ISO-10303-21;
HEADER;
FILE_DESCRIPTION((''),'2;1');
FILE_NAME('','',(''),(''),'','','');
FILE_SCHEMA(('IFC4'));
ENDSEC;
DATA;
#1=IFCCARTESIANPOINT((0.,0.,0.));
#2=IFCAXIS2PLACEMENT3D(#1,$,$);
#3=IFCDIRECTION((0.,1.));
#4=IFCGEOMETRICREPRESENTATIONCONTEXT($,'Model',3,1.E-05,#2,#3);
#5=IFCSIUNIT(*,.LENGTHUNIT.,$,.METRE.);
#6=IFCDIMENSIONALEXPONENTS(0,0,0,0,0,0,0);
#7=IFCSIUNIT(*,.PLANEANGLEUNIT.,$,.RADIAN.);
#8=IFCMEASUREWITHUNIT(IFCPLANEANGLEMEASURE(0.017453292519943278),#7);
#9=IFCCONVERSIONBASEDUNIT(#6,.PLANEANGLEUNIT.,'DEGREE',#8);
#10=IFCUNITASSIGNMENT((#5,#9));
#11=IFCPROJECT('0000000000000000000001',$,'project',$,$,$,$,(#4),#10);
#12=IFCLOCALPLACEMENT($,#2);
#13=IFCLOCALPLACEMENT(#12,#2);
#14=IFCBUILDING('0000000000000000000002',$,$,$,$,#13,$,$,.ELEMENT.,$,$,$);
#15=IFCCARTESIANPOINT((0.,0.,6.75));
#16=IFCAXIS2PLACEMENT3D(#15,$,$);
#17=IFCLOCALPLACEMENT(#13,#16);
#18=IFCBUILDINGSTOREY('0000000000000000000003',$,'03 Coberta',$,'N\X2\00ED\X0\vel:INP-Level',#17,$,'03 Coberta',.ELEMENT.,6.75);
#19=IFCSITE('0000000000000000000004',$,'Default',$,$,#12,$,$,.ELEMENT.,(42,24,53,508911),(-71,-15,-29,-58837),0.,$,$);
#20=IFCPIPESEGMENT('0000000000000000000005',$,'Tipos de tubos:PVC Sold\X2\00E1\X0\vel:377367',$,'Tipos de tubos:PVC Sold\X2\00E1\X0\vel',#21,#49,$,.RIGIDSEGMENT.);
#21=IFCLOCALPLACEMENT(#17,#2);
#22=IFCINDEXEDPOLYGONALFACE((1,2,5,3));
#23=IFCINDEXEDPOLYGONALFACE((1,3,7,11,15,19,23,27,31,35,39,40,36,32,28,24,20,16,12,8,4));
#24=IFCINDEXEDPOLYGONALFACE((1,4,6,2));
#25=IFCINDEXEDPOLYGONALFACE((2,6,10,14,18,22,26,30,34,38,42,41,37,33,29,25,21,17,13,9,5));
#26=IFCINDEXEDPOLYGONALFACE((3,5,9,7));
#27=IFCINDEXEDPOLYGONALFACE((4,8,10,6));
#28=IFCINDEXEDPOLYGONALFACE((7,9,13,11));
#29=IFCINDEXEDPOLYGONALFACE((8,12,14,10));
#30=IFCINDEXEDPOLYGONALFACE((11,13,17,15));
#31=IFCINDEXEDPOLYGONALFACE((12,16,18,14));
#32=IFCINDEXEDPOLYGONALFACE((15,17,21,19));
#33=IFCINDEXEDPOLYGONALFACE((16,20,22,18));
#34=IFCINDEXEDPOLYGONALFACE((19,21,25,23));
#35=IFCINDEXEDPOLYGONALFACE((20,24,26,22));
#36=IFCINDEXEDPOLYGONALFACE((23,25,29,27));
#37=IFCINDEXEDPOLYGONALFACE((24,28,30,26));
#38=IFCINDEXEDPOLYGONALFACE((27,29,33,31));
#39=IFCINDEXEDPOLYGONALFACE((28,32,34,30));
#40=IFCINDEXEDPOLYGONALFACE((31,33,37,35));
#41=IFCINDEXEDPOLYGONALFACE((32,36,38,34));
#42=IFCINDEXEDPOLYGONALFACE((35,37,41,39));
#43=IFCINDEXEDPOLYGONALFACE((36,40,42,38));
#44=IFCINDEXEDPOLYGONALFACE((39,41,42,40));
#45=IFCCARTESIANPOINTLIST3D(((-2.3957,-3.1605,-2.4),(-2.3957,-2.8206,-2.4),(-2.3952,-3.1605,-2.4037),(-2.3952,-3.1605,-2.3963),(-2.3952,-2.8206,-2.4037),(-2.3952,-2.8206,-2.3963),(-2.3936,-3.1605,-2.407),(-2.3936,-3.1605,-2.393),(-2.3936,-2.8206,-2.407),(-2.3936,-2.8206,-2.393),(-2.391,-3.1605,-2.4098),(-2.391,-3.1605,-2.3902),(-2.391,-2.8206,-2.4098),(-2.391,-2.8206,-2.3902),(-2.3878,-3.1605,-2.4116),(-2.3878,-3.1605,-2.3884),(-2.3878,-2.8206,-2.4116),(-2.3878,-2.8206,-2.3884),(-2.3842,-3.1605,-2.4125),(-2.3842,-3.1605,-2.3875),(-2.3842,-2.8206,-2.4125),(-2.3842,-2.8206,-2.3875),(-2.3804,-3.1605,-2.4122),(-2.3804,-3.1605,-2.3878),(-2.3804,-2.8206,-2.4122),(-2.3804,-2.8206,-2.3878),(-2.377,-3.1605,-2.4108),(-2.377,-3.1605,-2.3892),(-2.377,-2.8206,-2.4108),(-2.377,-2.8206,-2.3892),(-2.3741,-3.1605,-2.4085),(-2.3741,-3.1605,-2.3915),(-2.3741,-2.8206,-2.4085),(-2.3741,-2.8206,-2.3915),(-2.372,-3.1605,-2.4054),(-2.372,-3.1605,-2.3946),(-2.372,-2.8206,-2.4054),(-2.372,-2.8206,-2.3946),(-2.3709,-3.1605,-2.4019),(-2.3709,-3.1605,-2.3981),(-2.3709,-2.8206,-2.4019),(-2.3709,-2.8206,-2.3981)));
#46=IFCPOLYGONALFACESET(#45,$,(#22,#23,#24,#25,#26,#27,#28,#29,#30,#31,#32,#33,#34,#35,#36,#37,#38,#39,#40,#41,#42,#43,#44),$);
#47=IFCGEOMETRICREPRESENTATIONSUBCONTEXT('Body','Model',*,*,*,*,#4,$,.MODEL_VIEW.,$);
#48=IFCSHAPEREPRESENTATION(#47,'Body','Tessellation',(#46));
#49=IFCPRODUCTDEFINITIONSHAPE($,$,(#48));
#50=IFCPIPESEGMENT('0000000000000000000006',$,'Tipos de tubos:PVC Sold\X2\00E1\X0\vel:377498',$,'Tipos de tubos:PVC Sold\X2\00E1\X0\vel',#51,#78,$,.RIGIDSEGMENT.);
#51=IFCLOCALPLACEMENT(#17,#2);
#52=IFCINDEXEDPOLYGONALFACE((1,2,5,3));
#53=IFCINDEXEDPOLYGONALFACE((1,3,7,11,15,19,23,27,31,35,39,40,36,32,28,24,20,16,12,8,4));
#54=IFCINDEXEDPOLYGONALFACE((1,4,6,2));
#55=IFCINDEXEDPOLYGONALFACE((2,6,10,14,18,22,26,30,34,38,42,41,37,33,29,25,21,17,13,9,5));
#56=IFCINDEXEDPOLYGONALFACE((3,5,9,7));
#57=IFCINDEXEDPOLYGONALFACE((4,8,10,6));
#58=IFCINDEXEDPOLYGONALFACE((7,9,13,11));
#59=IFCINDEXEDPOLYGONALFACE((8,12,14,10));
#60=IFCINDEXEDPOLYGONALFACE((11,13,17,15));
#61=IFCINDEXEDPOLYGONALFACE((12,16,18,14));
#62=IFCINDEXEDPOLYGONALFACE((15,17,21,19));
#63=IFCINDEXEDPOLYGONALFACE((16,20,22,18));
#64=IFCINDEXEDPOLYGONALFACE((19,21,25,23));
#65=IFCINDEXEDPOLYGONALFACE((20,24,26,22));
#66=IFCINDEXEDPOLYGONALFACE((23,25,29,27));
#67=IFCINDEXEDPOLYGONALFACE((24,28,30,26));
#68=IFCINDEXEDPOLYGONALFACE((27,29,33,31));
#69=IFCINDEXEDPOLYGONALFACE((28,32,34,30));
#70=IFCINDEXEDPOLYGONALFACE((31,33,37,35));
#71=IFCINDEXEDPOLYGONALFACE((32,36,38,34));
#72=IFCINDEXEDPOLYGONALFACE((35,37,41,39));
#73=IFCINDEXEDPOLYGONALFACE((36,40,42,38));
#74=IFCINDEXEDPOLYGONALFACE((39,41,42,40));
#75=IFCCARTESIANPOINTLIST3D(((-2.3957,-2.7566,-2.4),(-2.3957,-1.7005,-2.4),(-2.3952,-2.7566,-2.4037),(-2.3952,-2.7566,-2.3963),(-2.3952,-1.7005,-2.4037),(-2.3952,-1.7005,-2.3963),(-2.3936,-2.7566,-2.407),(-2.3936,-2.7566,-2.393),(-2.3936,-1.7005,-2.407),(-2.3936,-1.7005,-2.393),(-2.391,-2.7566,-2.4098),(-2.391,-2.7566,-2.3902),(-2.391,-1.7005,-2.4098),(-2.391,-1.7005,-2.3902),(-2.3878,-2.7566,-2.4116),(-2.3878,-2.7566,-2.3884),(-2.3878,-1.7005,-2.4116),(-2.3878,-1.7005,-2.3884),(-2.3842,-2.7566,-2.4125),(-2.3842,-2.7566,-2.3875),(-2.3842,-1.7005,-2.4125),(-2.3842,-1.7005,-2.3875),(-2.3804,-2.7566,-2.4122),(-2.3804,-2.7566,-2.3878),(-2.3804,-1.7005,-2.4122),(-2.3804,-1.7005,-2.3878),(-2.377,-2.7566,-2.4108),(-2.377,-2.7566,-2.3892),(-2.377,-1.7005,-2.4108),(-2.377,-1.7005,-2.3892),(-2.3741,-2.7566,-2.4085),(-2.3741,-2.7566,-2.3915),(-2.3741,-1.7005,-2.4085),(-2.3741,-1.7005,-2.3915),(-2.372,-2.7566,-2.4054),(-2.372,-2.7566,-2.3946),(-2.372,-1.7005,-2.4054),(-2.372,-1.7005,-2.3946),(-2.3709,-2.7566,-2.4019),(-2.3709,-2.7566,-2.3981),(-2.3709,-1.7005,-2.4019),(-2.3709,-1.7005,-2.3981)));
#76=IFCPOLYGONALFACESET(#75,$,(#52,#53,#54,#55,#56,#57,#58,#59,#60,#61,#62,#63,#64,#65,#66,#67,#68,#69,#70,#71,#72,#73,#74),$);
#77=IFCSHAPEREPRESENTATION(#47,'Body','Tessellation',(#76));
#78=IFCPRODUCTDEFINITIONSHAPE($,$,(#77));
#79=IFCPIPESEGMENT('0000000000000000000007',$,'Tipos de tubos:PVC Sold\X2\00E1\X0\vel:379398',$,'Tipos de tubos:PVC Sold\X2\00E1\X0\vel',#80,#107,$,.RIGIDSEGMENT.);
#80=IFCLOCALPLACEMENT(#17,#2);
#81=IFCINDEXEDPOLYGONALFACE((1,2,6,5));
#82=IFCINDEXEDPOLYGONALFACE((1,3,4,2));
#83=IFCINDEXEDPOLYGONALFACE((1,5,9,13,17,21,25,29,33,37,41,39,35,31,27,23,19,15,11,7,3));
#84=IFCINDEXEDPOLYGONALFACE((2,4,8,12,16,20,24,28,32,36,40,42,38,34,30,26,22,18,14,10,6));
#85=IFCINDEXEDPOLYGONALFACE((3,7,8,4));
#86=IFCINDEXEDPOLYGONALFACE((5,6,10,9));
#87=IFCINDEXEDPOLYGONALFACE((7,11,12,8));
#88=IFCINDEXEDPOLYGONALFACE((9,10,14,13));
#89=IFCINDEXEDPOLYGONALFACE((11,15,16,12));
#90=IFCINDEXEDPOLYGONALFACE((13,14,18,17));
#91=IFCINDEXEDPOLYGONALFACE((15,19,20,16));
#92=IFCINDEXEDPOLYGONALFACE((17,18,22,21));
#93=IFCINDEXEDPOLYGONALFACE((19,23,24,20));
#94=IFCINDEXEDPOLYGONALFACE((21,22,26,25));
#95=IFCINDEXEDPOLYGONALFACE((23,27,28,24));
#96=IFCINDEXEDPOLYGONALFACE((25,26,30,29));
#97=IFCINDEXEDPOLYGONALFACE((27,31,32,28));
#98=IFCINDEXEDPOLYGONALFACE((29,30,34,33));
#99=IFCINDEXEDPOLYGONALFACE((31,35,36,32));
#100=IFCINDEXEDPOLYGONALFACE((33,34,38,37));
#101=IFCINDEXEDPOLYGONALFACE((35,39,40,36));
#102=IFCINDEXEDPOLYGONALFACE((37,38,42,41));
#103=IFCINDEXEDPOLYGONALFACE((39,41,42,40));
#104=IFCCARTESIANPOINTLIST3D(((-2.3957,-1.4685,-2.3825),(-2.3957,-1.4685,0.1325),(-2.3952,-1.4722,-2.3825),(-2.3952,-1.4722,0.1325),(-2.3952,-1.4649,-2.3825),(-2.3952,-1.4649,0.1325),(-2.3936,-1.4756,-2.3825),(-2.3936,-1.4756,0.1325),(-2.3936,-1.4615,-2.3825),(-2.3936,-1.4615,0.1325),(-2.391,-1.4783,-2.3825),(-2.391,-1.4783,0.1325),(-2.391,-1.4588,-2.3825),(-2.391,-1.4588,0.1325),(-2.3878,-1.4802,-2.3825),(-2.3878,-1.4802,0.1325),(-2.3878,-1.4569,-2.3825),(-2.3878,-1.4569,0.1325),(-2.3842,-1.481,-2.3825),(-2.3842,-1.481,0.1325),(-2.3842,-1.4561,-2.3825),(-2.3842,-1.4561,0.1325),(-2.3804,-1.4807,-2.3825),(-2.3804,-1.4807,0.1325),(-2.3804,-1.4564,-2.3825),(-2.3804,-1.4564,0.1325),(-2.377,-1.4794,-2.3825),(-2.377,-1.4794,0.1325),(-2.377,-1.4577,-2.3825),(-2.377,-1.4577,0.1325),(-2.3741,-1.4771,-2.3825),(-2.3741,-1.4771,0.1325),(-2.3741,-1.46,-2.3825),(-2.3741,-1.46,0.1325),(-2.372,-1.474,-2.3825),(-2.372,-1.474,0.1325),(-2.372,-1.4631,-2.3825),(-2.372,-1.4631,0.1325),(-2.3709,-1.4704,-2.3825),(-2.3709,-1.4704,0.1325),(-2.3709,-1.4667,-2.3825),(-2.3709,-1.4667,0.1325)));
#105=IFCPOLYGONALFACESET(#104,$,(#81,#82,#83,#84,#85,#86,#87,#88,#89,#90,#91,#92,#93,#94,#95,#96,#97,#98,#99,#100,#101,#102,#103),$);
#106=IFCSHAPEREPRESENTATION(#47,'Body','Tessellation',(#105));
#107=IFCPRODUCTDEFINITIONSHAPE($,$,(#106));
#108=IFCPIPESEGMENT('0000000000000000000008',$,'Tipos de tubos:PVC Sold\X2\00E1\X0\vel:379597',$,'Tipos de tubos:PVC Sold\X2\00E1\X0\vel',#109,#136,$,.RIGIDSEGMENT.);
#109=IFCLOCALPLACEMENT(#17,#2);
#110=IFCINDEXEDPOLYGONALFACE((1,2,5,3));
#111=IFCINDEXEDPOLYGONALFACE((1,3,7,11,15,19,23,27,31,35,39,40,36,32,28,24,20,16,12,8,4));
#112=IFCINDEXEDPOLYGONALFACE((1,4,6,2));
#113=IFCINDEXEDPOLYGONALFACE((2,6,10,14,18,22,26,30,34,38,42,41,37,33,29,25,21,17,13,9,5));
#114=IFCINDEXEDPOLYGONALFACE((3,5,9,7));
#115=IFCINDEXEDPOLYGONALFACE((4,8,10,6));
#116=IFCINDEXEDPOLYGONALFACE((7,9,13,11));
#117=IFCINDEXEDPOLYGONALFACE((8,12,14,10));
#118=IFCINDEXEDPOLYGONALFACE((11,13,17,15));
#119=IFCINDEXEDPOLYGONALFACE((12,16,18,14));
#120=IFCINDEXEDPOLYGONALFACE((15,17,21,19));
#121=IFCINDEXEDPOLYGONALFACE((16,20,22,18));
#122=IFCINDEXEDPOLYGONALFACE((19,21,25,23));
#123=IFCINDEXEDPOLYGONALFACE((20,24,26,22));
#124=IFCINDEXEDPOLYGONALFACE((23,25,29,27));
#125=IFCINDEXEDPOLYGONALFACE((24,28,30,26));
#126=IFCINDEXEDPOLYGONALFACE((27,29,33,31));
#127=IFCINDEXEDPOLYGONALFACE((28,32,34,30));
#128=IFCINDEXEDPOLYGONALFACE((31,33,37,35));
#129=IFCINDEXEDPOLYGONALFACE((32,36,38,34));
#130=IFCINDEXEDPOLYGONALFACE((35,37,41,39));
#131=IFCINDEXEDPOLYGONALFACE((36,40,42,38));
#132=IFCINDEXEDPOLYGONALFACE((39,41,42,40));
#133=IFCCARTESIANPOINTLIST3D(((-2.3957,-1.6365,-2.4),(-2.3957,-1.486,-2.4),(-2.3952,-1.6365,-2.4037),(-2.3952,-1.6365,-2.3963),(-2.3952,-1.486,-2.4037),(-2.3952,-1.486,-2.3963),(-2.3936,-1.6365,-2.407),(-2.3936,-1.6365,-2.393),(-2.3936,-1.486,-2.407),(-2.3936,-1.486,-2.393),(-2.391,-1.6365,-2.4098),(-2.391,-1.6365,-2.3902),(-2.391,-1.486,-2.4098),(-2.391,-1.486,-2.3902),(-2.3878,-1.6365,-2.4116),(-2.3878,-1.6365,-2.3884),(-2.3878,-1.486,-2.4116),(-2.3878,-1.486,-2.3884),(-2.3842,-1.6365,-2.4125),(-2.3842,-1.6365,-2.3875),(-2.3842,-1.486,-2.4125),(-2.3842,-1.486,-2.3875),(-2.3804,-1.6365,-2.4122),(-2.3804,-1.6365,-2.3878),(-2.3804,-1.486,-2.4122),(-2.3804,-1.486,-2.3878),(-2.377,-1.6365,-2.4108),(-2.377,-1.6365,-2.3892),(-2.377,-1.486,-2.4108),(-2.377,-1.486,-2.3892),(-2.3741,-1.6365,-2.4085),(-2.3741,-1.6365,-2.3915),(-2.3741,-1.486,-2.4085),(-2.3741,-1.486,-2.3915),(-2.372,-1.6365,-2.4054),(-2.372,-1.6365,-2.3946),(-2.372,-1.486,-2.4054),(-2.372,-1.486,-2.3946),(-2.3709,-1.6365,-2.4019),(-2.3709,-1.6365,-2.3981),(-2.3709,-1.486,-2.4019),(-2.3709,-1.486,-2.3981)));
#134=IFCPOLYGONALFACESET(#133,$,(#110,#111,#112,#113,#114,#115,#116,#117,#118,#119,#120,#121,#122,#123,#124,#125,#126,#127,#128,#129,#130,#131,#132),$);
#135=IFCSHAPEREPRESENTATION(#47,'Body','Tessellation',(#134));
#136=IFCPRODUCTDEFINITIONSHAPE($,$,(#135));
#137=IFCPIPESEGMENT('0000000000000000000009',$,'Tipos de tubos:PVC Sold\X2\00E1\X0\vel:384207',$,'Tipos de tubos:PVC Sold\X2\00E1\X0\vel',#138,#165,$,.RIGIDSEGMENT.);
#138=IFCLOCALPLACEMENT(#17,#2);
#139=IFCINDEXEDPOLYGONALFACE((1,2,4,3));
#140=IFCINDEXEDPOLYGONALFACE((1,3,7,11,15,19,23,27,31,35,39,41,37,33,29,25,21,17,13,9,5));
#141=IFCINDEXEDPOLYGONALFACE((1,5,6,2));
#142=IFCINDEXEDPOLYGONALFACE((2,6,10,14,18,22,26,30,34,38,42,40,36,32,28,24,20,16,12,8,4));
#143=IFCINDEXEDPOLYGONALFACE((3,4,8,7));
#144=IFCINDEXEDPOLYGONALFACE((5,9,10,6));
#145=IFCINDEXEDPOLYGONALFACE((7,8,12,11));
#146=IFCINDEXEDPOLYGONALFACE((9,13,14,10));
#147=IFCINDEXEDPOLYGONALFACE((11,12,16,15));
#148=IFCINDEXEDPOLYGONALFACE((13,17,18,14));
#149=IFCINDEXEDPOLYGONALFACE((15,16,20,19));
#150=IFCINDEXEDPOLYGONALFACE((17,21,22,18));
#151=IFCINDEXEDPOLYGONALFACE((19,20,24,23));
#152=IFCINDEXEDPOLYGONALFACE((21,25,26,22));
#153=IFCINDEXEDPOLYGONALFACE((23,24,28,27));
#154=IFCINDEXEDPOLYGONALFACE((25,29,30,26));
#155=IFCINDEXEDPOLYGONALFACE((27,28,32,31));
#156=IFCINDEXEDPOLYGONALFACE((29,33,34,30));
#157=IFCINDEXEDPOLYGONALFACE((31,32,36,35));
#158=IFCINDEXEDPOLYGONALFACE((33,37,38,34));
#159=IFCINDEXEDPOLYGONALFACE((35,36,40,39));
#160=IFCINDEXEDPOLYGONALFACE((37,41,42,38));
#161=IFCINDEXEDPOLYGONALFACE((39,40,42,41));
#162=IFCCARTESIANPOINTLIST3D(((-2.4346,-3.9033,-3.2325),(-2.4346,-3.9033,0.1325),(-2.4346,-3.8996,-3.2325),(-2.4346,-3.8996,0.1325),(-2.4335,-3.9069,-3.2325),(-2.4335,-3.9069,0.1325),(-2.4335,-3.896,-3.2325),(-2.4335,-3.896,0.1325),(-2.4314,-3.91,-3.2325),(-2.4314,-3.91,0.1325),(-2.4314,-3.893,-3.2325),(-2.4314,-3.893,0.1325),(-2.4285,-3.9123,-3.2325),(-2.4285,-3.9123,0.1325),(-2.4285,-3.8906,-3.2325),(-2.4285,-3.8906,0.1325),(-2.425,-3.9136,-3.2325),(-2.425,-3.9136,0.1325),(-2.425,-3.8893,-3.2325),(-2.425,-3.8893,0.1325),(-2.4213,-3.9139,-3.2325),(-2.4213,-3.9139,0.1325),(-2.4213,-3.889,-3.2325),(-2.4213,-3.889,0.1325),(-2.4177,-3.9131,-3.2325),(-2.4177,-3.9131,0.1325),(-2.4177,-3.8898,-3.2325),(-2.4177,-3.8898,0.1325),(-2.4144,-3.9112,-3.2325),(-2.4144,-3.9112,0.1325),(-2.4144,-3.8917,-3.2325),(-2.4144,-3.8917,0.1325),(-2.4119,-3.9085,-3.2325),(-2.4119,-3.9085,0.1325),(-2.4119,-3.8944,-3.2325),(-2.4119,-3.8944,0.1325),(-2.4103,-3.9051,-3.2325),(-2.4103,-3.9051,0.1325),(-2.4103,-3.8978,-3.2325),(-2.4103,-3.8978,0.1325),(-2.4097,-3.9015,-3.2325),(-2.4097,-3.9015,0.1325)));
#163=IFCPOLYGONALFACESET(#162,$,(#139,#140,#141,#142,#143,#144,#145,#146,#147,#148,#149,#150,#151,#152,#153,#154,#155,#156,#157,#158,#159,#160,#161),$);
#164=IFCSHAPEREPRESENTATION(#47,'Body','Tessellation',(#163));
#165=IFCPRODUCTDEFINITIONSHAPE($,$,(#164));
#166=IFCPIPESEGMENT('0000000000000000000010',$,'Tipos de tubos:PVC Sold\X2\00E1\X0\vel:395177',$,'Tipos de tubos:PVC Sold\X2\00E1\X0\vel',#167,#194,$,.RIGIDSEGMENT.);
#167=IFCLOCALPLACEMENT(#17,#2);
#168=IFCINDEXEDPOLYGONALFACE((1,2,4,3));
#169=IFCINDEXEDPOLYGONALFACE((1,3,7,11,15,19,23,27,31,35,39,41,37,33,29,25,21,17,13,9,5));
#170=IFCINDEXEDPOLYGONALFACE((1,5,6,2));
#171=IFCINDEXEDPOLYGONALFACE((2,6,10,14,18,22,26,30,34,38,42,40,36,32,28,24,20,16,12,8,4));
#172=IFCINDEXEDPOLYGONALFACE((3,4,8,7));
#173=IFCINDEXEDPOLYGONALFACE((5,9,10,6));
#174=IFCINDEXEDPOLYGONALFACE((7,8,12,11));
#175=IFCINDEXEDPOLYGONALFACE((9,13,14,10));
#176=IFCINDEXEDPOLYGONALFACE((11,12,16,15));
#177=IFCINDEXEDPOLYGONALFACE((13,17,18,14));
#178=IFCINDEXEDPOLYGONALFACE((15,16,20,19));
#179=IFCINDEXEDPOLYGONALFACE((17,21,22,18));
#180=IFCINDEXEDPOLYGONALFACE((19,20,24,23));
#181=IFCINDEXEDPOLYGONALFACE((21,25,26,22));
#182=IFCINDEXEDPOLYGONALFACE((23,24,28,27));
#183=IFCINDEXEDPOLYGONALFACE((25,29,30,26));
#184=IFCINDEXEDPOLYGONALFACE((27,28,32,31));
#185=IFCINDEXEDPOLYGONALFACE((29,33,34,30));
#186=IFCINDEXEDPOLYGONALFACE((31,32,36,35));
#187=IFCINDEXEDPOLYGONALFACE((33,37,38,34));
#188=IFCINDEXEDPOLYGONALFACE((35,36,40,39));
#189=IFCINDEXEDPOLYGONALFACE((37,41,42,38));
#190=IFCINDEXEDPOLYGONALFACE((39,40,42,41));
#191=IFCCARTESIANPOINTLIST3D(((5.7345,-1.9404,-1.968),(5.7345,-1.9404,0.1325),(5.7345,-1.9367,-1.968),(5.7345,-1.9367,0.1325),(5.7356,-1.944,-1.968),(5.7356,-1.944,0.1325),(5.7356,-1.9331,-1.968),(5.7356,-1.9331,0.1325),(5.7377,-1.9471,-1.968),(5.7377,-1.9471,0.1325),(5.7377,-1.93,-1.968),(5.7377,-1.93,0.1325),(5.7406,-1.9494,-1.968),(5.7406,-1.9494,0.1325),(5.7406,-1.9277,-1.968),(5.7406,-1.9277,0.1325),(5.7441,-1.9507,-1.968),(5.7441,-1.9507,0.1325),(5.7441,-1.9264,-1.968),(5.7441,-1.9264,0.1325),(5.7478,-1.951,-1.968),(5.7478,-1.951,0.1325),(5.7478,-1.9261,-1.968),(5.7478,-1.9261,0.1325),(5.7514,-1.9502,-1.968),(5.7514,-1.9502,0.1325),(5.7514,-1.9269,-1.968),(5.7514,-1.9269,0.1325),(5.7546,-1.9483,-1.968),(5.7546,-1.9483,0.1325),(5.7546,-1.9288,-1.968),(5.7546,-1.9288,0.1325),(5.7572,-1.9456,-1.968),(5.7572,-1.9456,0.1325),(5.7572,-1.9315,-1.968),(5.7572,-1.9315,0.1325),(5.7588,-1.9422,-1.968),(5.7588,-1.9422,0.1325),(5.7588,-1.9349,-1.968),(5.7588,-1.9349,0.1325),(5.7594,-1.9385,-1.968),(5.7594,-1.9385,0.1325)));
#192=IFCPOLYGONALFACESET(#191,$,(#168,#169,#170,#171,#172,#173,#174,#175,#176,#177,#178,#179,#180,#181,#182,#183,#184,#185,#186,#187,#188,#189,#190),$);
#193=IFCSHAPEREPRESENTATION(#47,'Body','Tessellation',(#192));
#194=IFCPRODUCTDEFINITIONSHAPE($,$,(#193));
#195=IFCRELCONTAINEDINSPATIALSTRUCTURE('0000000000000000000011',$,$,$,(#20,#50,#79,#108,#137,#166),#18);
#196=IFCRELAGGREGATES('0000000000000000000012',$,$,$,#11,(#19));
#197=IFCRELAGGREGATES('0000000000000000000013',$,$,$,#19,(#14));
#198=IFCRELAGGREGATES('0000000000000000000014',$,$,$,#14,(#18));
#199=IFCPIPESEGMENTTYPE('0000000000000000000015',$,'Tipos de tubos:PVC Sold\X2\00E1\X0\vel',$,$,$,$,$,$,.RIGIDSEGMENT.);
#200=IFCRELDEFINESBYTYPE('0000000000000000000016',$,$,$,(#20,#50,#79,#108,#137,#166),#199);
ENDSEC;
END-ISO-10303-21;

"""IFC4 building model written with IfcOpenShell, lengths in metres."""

from ifc_helpers import new_model, entity, si_unit, converted_unit, direction, frame, frame_2d, origin, origin_2d_with_axis, place, context, subcontext, project, spatial, circle, extrude, type_object, element, save


model = new_model("IFC4")

# Units and contexts
model_context = context("Model", 3, precision=1e-05, world=origin(), true_north=direction((0.0, 1.0)))
body_context = subcontext(model_context, "Body", "Model", "MODEL_VIEW")
ifc_project = project(units=[si_unit("LENGTHUNIT", "METRE"), converted_unit("PLANEANGLEUNIT", "DEGREE", entity("IfcPlaneAngleMeasure", 0.017453292519943278), si_unit("PLANEANGLEUNIT", "RADIAN"), dimensions=[0, 0, 0, 0, 0, 0, 0])], contexts=[model_context])

# Site, building, storey
site_placement = place(None, origin())
site = spatial("IfcSite", under=ifc_project, at=site_placement, Name="Default", CompositionType="ELEMENT", RefLatitude=(42, 24, 53, 508911), RefLongitude=(-71, -15, -29, -58837), RefElevation=0.0)
building_placement = place(site_placement, origin())
building = spatial("IfcBuilding", under=site, at=building_placement, CompositionType="ELEMENT")
storey_placement = place(building_placement, frame((0.0, 0.0, 6.75)))
storey = spatial("IfcBuildingStorey", under=building, at=storey_placement, Name="03 Coberta", ObjectType="Nível:INP-Level", LongName="03 Coberta", CompositionType="ELEMENT", Elevation=6.75)

# Pipe segments
pipe_segment_type = type_object("IfcPipeSegmentType", Name="Tipos de tubos:PVC Soldável", PredefinedType="RIGIDSEGMENT")
pipe_segment_1_placement = place(storey_placement, frame((-2.3973, -3.1605, -2.3859)))
element("IfcPipeSegment", 1, at=pipe_segment_1_placement, inside=storey, type_object=pipe_segment_type, Name="Tipos de tubos:PVC Soldável:377367", ObjectType="Tipos de tubos:PVC Soldável", PredefinedType="RIGIDSEGMENT", context=body_context, shape_type="SweptSolid", body=[
    extrude(circle(Radius=0.0125, at=frame_2d((0.0, 0.0), x_axis=(1.0, 0.0))), frame((0.0141, 0.0, -0.0141), z_axis=(0.0, 1.0, 0.0), x_axis=(-1.0, 0.0, 0.0)), (0.0, 0.0, 1.0), 0.3398),
])
pipe_segment_2_placement = place(storey_placement, frame((-2.3973, -2.7566, -2.3859)))
element("IfcPipeSegment", 2, at=pipe_segment_2_placement, inside=storey, type_object=pipe_segment_type, Name="Tipos de tubos:PVC Soldável:377498", ObjectType="Tipos de tubos:PVC Soldável", PredefinedType="RIGIDSEGMENT", context=body_context, shape_type="SweptSolid", body=[
    extrude(circle(Radius=0.0125, at=frame_2d((0.0, 0.0), x_axis=(1.0, 0.0))), frame((0.0141, 0.0, -0.0141), z_axis=(0.0, 1.0, 0.0), x_axis=(-1.0, 0.0, 0.0)), (0.0, 0.0, 1.0), 1.0561),
])
pipe_segment_3_placement = place(storey_placement, frame((-2.3973, -1.4826, 0.1325)))
element("IfcPipeSegment", 3, at=pipe_segment_3_placement, inside=storey, type_object=pipe_segment_type, Name="Tipos de tubos:PVC Soldável:379398", ObjectType="Tipos de tubos:PVC Soldável", PredefinedType="RIGIDSEGMENT", context=body_context, shape_type="SweptSolid", body=[
    extrude(circle(Radius=0.0125, at=frame_2d((0.0, 0.0), x_axis=(1.0, 0.0))), frame((0.0141, 0.0141, -2.515), z_axis=(0.0, 0.0, 1.0), x_axis=(-1.0, 0.0, 0.0)), (0.0, 0.0, 1.0), 2.515),
])
pipe_segment_4_placement = place(storey_placement, frame((-2.3973, -1.6365, -2.3859)))
element("IfcPipeSegment", 4, at=pipe_segment_4_placement, inside=storey, type_object=pipe_segment_type, Name="Tipos de tubos:PVC Soldável:379597", ObjectType="Tipos de tubos:PVC Soldável", PredefinedType="RIGIDSEGMENT", context=body_context, shape_type="SweptSolid", body=[
    extrude(circle(Radius=0.0125, at=frame_2d((0.0, 0.0), x_axis=(1.0, 0.0))), frame((0.0141, 0.0, -0.0141), z_axis=(0.0, 1.0, 0.0), x_axis=(-1.0, 0.0, 0.0)), (0.0, 0.0, 1.0), 0.1505),
])
pipe_segment_5_placement = place(storey_placement, frame((-2.4363, -3.9155, 0.1325)))
element("IfcPipeSegment", 5, at=pipe_segment_5_placement, inside=storey, type_object=pipe_segment_type, Name="Tipos de tubos:PVC Soldável:384207", ObjectType="Tipos de tubos:PVC Soldável", PredefinedType="RIGIDSEGMENT", context=body_context, shape_type="SweptSolid", body=[
    extrude(circle(Radius=0.0125, at=frame_2d((0.0, 0.0), x_axis=(1.0, 0.0))), frame((0.0141, 0.0141, -3.365)), (0.0, 0.0, 1.0), 3.365),
])
pipe_segment_6_placement = place(storey_placement, frame((5.7328, -1.9526, 0.1325)))
element("IfcPipeSegment", 6, at=pipe_segment_6_placement, inside=storey, type_object=pipe_segment_type, Name="Tipos de tubos:PVC Soldável:395177", ObjectType="Tipos de tubos:PVC Soldável", PredefinedType="RIGIDSEGMENT", context=body_context, shape_type="SweptSolid", body=[
    extrude(circle(Radius=0.0125, at=origin_2d_with_axis()), frame((0.0141, 0.0141, -2.1005)), (0.0, 0.0, 1.0), 2.1005),
])

save(model, "model.ifc")
